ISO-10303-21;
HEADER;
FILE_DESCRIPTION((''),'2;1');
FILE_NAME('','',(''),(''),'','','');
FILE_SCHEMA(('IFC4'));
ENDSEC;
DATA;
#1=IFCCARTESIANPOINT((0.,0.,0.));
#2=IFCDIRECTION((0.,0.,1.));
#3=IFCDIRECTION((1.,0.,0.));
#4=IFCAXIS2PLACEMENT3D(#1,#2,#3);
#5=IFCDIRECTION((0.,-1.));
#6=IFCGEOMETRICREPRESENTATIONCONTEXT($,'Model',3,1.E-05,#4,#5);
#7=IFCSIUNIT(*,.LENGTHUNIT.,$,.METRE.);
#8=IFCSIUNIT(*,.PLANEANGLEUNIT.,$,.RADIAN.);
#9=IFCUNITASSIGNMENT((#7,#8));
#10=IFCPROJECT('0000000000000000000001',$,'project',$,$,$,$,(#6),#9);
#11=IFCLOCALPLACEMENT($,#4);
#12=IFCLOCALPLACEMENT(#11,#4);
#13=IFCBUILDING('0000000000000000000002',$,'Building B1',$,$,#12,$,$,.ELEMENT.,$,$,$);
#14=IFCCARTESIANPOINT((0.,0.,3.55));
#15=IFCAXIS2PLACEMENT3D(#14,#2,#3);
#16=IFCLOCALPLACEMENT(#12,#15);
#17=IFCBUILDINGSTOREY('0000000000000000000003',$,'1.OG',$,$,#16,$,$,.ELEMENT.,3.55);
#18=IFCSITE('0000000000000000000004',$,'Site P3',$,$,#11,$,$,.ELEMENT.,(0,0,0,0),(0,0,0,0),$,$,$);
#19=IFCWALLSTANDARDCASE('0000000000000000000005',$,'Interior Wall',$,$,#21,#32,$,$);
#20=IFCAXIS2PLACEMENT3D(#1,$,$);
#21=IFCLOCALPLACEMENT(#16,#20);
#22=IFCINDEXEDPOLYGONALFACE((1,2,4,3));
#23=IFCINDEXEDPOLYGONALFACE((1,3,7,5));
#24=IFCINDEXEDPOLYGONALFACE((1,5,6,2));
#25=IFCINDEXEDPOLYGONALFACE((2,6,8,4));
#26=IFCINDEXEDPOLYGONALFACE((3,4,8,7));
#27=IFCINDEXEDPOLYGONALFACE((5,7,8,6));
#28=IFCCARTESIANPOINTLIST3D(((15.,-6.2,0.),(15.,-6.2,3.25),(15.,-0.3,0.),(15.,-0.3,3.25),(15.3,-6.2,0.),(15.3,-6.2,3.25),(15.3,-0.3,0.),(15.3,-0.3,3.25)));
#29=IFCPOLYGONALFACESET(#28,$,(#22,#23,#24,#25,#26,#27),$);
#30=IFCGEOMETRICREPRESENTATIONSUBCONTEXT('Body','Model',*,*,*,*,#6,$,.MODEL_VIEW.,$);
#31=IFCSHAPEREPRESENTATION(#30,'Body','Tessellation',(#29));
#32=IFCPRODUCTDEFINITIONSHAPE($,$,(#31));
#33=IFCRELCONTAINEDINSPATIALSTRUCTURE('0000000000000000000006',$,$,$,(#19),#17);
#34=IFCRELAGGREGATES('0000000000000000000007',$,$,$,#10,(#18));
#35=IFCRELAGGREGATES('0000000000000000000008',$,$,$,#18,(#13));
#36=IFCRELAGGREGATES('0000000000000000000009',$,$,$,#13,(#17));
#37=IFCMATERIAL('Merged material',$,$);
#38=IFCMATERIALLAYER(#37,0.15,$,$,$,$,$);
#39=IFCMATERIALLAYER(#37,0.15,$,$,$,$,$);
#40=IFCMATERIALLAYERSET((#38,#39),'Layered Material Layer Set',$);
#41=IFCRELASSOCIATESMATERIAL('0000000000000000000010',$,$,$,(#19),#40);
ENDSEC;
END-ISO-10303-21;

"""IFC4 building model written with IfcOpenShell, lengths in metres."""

from ifc_helpers import new_model, si_unit, direction, frame, origin_with_axes, place, context, subcontext, project, spatial, polyline, outline, extrude, material, layer, layer_set, layer_usage, element, save


model = new_model("IFC4")

# Units and contexts
model_context = context("Model", 3, precision=1e-05, world=origin_with_axes(), true_north=direction((0.0, -1.0)))
body_context = subcontext(model_context, "Body", "Model", "MODEL_VIEW")
ifc_project = project(units=[si_unit("LENGTHUNIT", "METRE"), si_unit("PLANEANGLEUNIT", "RADIAN")], contexts=[model_context])

# Site, building, storey
site_placement = place(None, origin_with_axes())
site = spatial("IfcSite", under=ifc_project, at=site_placement, Name="Site P3", CompositionType="ELEMENT", RefLatitude=(0, 0, 0, 0), RefLongitude=(0, 0, 0, 0))
building_placement = place(site_placement, origin_with_axes())
building = spatial("IfcBuilding", under=site, at=building_placement, Name="Building B1", CompositionType="ELEMENT")
storey_placement = place(building_placement, frame((0.0, 0.0, 3.55), z_axis=(0.0, 0.0, 1.0), x_axis=(1.0, 0.0, 0.0)))
storey = spatial("IfcBuildingStorey", under=building, at=storey_placement, Name="1.OG", CompositionType="ELEMENT", Elevation=3.55)

# Shared definitions
ifc_material = material(Name="Merged material")

# Shared definitions
ifc_layer_1 = layer(ifc_material, 0.15)
ifc_layer_2 = layer(ifc_material, 0.15)
ifc_layer_set_1 = layer_set([ifc_layer_1, ifc_layer_2], Name="Layered Material Layer Set")
ifc_layer_usage_1 = layer_usage(ifc_layer_set_1, "AXIS2", "POSITIVE", -0.15)

# Wall
wall_1_placement = place(storey_placement, frame((15.15, -0.3, 0.0), z_axis=(0.0, 0.0, 1.0), x_axis=(0.0, -1.0, 0.0)))
element("IfcWallStandardCase", 1, at=wall_1_placement, inside=storey, material=ifc_layer_usage_1, Name="Interior Wall", context=body_context, shape_type="SweptSolid", body=[
    extrude(outline(polyline([(0.0, 0.15), (5.9, 0.15), (5.9, -0.15), (0.0, -0.15), (0.0, 0.15)])), origin_with_axes(), (0.0, 0.0, 1.0), 3.25),
])

save(model, "model.ifc")
